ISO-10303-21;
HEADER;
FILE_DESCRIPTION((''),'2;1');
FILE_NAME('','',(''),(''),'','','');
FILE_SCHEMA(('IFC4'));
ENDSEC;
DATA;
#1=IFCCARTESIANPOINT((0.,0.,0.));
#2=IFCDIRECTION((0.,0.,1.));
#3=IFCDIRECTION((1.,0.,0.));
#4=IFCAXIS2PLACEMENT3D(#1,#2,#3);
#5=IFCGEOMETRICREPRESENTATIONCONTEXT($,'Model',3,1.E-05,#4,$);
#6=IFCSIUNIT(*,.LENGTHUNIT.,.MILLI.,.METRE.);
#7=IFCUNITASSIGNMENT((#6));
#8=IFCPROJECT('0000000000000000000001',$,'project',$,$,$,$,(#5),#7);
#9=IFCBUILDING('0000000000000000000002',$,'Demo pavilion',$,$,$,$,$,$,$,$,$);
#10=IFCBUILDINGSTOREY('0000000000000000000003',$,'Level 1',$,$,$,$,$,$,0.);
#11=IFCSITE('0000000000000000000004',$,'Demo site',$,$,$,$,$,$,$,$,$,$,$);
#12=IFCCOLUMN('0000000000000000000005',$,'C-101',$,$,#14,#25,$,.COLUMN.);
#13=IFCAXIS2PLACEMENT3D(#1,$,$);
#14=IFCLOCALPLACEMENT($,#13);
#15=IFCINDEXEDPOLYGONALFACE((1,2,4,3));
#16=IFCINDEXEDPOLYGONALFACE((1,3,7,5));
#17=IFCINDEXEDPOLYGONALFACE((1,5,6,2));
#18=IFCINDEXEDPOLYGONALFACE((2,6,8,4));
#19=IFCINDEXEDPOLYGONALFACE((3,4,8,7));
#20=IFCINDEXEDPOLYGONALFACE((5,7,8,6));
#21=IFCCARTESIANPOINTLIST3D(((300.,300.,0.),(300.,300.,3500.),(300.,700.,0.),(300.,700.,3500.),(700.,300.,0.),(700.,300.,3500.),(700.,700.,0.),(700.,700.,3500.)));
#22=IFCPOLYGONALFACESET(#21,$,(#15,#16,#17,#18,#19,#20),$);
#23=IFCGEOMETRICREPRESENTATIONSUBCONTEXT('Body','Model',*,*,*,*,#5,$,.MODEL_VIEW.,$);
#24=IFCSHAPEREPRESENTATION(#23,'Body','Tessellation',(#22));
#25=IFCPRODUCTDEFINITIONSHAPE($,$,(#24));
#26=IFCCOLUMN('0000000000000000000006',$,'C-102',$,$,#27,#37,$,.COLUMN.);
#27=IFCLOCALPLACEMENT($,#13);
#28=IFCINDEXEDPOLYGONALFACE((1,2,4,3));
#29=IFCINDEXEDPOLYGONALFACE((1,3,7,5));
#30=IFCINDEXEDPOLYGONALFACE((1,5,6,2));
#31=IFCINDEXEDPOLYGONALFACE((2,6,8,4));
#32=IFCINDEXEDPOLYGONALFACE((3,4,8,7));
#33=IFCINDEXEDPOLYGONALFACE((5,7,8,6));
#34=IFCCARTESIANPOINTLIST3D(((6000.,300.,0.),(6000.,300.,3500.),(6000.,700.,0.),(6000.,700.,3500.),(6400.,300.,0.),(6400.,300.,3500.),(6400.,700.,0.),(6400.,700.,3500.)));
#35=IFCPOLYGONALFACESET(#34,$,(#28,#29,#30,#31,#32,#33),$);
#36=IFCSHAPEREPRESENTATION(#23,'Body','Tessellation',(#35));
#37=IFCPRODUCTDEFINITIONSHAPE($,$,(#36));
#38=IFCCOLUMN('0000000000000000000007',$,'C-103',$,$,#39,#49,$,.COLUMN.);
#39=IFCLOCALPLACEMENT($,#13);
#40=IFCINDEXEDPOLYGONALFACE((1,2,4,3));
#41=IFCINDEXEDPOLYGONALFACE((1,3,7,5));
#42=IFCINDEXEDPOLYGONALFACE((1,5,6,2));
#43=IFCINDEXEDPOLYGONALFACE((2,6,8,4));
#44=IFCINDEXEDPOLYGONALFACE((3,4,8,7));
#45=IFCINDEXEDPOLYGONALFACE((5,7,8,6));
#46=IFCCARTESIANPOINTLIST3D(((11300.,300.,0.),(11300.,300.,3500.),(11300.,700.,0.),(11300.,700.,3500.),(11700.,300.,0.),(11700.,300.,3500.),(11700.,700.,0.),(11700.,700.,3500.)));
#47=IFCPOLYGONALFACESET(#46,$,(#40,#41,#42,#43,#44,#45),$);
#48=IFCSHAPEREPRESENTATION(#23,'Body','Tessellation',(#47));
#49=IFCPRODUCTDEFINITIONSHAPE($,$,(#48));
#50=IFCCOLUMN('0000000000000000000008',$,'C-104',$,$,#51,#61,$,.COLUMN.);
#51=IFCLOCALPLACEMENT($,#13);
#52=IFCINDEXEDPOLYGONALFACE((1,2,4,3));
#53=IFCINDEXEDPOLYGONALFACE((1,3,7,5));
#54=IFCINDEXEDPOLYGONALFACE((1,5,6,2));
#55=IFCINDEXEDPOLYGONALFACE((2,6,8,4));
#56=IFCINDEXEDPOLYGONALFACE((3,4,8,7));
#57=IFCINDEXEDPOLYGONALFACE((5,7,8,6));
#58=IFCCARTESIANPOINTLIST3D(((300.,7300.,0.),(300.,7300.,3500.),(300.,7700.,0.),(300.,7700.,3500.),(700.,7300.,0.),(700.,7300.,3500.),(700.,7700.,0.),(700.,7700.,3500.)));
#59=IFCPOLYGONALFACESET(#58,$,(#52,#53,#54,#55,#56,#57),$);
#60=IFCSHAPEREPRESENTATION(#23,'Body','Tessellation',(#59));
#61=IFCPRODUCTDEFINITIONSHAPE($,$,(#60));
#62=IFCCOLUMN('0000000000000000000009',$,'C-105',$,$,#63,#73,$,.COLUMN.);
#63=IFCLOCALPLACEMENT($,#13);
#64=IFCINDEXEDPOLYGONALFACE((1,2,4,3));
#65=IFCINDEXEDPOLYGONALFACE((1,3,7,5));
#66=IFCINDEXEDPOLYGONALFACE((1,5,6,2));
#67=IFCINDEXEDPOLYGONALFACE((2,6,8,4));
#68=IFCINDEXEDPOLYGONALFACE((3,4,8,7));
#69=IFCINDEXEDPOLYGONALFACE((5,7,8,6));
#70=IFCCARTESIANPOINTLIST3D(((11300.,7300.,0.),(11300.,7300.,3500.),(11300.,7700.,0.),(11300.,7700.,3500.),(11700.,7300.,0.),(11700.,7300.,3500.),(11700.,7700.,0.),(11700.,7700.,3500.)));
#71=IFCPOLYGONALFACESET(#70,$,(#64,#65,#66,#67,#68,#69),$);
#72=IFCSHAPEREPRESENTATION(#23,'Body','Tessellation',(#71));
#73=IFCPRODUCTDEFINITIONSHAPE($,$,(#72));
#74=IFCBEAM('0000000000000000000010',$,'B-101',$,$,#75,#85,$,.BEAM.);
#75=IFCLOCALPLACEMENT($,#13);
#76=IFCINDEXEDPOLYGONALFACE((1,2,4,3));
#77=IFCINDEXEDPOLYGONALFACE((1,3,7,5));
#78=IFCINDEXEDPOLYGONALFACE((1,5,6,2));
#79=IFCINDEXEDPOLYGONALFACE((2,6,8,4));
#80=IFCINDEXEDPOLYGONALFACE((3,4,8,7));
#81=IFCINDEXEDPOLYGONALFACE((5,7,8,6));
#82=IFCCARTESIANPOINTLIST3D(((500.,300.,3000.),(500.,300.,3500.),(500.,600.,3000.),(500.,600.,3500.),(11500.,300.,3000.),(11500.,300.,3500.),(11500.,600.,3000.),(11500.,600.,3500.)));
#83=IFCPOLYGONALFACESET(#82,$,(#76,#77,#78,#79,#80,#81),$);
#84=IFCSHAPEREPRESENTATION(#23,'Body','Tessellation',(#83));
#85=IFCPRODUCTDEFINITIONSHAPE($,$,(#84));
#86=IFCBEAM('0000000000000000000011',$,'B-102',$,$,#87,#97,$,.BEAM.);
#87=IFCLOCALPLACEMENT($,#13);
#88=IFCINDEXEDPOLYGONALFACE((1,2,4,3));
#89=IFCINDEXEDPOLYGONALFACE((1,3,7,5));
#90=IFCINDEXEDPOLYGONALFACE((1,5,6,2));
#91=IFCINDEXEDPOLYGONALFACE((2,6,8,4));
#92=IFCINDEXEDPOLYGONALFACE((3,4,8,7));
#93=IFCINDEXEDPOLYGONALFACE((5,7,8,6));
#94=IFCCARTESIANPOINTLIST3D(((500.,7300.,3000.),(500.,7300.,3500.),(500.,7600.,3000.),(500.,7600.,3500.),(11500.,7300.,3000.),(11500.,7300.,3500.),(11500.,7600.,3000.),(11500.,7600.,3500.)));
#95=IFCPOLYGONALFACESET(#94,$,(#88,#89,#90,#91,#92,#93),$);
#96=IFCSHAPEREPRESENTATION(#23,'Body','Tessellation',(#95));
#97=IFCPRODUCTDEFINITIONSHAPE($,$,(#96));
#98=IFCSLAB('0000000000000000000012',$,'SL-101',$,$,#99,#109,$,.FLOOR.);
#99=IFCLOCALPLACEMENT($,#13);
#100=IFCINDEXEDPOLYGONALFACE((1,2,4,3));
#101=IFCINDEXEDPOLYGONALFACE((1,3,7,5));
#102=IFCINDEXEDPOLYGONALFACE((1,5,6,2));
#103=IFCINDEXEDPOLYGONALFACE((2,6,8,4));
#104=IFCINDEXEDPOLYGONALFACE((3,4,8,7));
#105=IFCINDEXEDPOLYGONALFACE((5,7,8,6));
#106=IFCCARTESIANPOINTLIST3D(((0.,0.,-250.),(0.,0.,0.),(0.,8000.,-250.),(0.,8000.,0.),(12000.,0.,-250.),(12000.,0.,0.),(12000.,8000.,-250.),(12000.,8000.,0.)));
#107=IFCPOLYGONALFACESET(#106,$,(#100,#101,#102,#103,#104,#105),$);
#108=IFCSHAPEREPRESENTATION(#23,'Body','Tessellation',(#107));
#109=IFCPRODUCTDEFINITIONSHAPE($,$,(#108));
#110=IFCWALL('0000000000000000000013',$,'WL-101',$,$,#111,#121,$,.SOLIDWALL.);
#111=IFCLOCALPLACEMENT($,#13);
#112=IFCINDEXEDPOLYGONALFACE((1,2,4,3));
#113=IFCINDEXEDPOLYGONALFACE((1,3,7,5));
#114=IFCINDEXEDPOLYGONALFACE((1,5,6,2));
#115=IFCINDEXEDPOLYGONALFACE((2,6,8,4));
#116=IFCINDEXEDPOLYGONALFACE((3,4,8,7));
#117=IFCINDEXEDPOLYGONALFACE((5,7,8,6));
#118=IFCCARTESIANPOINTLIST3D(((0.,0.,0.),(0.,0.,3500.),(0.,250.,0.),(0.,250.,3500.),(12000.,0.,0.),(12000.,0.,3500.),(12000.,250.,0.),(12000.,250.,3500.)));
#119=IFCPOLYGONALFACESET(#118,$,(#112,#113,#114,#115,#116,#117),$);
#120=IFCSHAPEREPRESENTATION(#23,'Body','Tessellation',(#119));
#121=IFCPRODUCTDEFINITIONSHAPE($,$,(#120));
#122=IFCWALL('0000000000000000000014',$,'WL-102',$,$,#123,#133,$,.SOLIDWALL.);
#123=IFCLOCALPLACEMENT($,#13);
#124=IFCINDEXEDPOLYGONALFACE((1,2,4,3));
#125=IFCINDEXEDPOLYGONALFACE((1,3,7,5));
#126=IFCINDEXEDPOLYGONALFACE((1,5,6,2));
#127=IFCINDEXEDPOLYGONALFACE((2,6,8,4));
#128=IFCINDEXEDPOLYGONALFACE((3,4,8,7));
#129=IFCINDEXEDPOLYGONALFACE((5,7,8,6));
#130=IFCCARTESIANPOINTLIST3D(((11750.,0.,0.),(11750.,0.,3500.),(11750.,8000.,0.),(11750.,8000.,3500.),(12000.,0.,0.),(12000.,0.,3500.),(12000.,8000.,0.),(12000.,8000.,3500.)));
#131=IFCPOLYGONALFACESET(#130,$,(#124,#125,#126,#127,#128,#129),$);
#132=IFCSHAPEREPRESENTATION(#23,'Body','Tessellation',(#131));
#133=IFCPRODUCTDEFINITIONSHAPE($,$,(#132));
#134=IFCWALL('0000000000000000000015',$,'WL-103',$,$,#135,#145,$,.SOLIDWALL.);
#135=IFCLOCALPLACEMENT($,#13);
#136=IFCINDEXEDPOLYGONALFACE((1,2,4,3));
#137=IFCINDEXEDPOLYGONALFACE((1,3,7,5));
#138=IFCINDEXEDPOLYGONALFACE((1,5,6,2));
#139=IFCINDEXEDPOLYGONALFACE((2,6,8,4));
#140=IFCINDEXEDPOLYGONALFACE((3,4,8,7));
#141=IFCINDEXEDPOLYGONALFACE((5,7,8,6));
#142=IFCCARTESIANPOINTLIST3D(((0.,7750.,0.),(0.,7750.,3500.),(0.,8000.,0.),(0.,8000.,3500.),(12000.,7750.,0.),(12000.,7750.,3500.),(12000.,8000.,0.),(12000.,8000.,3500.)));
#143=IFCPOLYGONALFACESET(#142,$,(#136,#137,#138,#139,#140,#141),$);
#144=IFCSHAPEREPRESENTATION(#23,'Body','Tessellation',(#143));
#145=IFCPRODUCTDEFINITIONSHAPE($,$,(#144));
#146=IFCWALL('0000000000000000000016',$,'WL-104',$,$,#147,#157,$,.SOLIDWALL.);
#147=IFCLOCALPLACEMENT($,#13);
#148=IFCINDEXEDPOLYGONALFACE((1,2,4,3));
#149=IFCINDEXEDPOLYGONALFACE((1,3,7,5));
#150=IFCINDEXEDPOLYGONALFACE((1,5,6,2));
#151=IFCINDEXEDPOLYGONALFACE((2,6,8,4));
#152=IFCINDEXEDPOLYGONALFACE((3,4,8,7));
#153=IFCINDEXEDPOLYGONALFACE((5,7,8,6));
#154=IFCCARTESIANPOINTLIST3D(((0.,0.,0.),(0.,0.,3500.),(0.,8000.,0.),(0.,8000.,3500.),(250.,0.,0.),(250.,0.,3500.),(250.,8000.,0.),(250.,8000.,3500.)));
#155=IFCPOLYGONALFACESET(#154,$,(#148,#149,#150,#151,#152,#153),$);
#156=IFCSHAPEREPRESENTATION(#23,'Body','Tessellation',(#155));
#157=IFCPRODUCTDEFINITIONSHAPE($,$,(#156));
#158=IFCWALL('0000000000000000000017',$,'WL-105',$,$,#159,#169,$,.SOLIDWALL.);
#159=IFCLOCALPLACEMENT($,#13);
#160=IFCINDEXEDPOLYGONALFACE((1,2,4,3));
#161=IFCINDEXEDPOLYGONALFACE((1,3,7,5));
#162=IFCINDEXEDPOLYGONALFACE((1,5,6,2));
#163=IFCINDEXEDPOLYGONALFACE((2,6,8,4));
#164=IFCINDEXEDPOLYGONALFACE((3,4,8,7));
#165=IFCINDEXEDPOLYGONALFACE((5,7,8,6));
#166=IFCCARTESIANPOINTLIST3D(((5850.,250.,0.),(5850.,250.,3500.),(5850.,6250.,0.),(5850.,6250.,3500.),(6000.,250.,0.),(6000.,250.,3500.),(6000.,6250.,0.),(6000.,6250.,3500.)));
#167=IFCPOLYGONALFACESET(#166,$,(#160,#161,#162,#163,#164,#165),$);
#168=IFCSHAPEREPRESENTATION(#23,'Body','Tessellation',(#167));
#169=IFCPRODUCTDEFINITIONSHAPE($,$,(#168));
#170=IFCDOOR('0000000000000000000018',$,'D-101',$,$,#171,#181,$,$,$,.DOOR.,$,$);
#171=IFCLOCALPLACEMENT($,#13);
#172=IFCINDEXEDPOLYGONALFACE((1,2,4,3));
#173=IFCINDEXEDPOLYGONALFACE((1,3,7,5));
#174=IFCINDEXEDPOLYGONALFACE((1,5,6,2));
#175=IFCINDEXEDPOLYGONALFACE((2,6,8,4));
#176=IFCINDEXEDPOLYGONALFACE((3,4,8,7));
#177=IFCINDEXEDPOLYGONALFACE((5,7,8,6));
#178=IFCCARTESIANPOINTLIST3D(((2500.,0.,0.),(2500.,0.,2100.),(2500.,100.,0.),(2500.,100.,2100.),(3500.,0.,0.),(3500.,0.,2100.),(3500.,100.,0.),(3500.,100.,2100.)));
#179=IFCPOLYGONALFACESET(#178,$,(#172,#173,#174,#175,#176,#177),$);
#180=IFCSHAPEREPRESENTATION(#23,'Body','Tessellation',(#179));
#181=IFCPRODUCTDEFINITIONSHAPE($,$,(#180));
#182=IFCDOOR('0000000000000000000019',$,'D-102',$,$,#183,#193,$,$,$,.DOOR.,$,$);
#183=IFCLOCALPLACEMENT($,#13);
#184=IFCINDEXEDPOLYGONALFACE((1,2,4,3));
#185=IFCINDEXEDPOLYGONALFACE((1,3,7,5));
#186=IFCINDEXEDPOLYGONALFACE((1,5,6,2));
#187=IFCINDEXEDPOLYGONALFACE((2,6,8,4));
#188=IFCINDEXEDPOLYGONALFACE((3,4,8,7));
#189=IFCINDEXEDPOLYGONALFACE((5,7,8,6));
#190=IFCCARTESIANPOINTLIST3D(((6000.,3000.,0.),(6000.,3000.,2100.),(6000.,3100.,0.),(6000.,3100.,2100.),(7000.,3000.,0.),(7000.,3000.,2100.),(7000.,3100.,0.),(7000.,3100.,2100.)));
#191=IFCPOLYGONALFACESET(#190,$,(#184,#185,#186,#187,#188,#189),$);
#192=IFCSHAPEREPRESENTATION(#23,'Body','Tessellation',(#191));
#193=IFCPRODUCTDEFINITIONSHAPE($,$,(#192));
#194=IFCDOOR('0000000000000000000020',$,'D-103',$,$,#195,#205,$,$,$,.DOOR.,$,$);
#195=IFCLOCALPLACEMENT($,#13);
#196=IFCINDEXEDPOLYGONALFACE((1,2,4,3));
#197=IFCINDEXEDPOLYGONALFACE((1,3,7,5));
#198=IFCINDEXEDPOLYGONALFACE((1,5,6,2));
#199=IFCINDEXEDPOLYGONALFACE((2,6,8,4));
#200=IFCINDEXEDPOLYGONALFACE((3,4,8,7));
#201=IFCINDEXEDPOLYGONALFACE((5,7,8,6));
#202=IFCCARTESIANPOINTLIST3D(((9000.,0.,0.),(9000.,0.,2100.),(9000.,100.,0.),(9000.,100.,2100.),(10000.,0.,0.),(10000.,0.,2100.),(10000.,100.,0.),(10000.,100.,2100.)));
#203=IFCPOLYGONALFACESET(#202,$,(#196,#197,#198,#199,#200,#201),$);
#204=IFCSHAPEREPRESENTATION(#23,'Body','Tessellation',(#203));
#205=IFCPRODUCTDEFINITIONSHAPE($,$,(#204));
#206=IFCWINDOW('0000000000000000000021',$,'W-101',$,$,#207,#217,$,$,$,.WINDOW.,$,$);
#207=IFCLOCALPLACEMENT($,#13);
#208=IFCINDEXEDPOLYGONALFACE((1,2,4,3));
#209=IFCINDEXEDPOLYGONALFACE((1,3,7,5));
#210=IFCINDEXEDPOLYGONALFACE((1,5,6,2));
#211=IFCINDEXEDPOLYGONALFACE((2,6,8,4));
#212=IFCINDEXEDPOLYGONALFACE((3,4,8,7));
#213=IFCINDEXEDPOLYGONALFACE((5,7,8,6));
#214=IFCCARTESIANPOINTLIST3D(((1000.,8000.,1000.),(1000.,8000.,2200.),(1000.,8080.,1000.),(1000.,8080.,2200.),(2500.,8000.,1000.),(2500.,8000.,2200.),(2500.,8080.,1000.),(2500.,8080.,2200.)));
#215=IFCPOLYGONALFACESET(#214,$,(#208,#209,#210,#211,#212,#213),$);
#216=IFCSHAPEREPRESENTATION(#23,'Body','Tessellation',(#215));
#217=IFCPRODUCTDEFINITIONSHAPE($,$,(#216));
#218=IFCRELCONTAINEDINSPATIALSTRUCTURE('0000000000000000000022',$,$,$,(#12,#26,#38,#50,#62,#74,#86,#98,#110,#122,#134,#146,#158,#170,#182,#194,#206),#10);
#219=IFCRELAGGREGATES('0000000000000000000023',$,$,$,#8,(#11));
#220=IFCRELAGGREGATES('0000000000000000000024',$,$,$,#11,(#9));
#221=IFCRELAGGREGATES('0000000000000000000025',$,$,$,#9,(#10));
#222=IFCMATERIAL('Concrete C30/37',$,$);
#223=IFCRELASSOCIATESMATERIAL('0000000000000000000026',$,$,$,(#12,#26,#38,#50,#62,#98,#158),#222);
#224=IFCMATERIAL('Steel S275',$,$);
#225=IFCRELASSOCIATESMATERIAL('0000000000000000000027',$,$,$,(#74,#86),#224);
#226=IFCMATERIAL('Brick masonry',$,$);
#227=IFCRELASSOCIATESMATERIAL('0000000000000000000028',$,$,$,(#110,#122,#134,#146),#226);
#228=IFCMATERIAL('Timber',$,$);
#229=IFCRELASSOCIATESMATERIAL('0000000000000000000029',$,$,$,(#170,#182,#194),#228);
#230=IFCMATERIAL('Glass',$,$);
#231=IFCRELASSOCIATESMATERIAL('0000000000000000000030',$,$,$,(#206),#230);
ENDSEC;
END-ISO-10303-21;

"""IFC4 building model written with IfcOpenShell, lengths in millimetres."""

from ifc_helpers import new_model, si_unit, frame, origin_with_axes, place, context, subcontext, project, spatial, indexed_curve, outline, extrude, material, element, save


model = new_model("IFC4")

# Units and contexts
model_context = context("Model", 3, precision=1e-05, world=origin_with_axes())
body_context = subcontext(model_context, "Body", "Model", "MODEL_VIEW")
ifc_project = project(units=[si_unit("LENGTHUNIT", "METRE", prefix="MILLI")], contexts=[model_context])

# Site, building, storey
site = spatial("IfcSite", under=ifc_project, Name="Demo site")
building = spatial("IfcBuilding", under=site, Name="Demo pavilion")
storey = spatial("IfcBuildingStorey", under=building, Name="Level 1", Elevation=0.0)

# Columns
ifc_material_1 = material(Name="Concrete C30/37")
for number, where, z_axis, x_axis, name in (
    (1, (300.0, 300.0, 0.0), (0.0, 0.0, 1.0), (1.0, 0.0, 0.0), "C-101"),
    (2, (6000.0, 300.0, 0.0), (0.0, 0.0, 1.0), (1.0, 0.0, 0.0), "C-102"),
    (3, (11300.0, 300.0, 0.0), (0.0, 0.0, 1.0), (1.0, 0.0, 0.0), "C-103"),
    (4, (300.0, 7300.0, 0.0), (0.0, 0.0, 1.0), (1.0, 0.0, 0.0), "C-104"),
    (5, (11300.0, 7300.0, 0.0), (0.0, 0.0, 1.0), (1.0, 0.0, 0.0), "C-105"),
):
    element("IfcColumn", number, at=place(None, frame(where, z_axis=z_axis, x_axis=x_axis)), inside=storey, material=ifc_material_1, Name=name, PredefinedType="COLUMN", context=body_context, shape_type="SweptSolid", body=[
        extrude(outline(indexed_curve([(0.0, 0.0), (0.0, 400.0), (400.0, 400.0), (400.0, 0.0), (0.0, 0.0)], self_intersect=False)), origin_with_axes(), (0.0, 0.0, 1.0), 3500.0),
    ])

# Beams
ifc_material_2 = material(Name="Steel S275")
for number, where, z_axis, x_axis, name in (
    (6, (500.0, 300.0, 3000.0), (0.0, 0.0, 1.0), (1.0, 0.0, 0.0), "B-101"),
    (7, (500.0, 7300.0, 3000.0), (0.0, 0.0, 1.0), (1.0, 0.0, 0.0), "B-102"),
):
    element("IfcBeam", number, at=place(None, frame(where, z_axis=z_axis, x_axis=x_axis)), inside=storey, material=ifc_material_2, Name=name, PredefinedType="BEAM", context=body_context, shape_type="SweptSolid", body=[
        extrude(outline(indexed_curve([(0.0, 0.0), (0.0, 300.0), (11000.0, 300.0), (11000.0, 0.0), (0.0, 0.0)], self_intersect=False)), origin_with_axes(), (0.0, 0.0, 1.0), 500.0),
    ])

# Slab
slab_placement = place(None, frame((0.0, 0.0, -250.0), z_axis=(0.0, 0.0, 1.0), x_axis=(1.0, 0.0, 0.0)))
element("IfcSlab", 8, at=slab_placement, inside=storey, material=ifc_material_1, Name="SL-101", PredefinedType="FLOOR", context=body_context, shape_type="SweptSolid", body=[
    extrude(outline(indexed_curve([(0.0, 0.0), (0.0, 8000.0), (12000.0, 8000.0), (12000.0, 0.0), (0.0, 0.0)], self_intersect=False)), origin_with_axes(), (0.0, 0.0, 1.0), 250.0),
])

# Walls
ifc_material_3 = material(Name="Brick masonry")
wall_1_placement = place(None, origin_with_axes())
element("IfcWall", 9, at=wall_1_placement, inside=storey, material=ifc_material_3, Name="WL-101", PredefinedType="SOLIDWALL", context=body_context, shape_type="SweptSolid", body=[
    extrude(outline(indexed_curve([(0.0, 0.0), (0.0, 250.0), (12000.0, 250.0), (12000.0, 0.0), (0.0, 0.0)], self_intersect=False)), origin_with_axes(), (0.0, 0.0, 1.0), 3500.0),
])
wall_2_placement = place(None, frame((12000.0, 0.0, 0.0), z_axis=(0.0, 0.0, 1.0), x_axis=(0.0, 1.0, 0.0)))
element("IfcWall", 10, at=wall_2_placement, inside=storey, material=ifc_material_3, Name="WL-102", PredefinedType="SOLIDWALL", context=body_context, shape_type="SweptSolid", body=[
    extrude(outline(indexed_curve([(0.0, 0.0), (0.0, 250.0), (8000.0, 250.0), (8000.0, 0.0), (0.0, 0.0)], self_intersect=False)), origin_with_axes(), (0.0, 0.0, 1.0), 3500.0),
])
wall_3_placement = place(None, frame((12000.0, 8000.0, 0.0), z_axis=(0.0, 0.0, 1.0), x_axis=(-1.0, 0.0, 0.0)))
element("IfcWall", 11, at=wall_3_placement, inside=storey, material=ifc_material_3, Name="WL-103", PredefinedType="SOLIDWALL", context=body_context, shape_type="SweptSolid", body=[
    extrude(outline(indexed_curve([(0.0, 0.0), (0.0, 250.0), (12000.0, 250.0), (12000.0, 0.0), (0.0, 0.0)], self_intersect=False)), origin_with_axes(), (0.0, 0.0, 1.0), 3500.0),
])
wall_4_placement = place(None, frame((0.0, 8000.0, 0.0), z_axis=(0.0, 0.0, 1.0), x_axis=(0.0, -1.0, 0.0)))
element("IfcWall", 12, at=wall_4_placement, inside=storey, material=ifc_material_3, Name="WL-104", PredefinedType="SOLIDWALL", context=body_context, shape_type="SweptSolid", body=[
    extrude(outline(indexed_curve([(0.0, 0.0), (0.0, 250.0), (8000.0, 250.0), (8000.0, 0.0), (0.0, 0.0)], self_intersect=False)), origin_with_axes(), (0.0, 0.0, 1.0), 3500.0),
])
wall_5_placement = place(None, frame((6000.0, 250.0, 0.0), z_axis=(0.0, 0.0, 1.0), x_axis=(0.0, 1.0, 0.0)))
element("IfcWall", 13, at=wall_5_placement, inside=storey, material=ifc_material_1, Name="WL-105", PredefinedType="SOLIDWALL", context=body_context, shape_type="SweptSolid", body=[
    extrude(outline(indexed_curve([(0.0, 0.0), (0.0, 150.0), (6000.0, 150.0), (6000.0, 0.0), (0.0, 0.0)], self_intersect=False)), origin_with_axes(), (0.0, 0.0, 1.0), 3500.0),
])

# Doors
ifc_material_4 = material(Name="Timber")
for number, where, z_axis, x_axis, name in (
    (14, (2500.0, 0.0, 0.0), (0.0, 0.0, 1.0), (1.0, 0.0, 0.0), "D-101"),
    (15, (6000.0, 3000.0, 0.0), (0.0, 0.0, 1.0), (1.0, 0.0, 0.0), "D-102"),
    (16, (9000.0, 0.0, 0.0), (0.0, 0.0, 1.0), (1.0, 0.0, 0.0), "D-103"),
):
    element("IfcDoor", number, at=place(None, frame(where, z_axis=z_axis, x_axis=x_axis)), inside=storey, material=ifc_material_4, Name=name, PredefinedType="DOOR", context=body_context, shape_type="SweptSolid", body=[
        extrude(outline(indexed_curve([(0.0, 0.0), (0.0, 100.0), (1000.0, 100.0), (1000.0, 0.0), (0.0, 0.0)], self_intersect=False)), origin_with_axes(), (0.0, 0.0, 1.0), 2100.0),
    ])

# Window
ifc_material_5 = material(Name="Glass")
for number, where, z_axis, x_axis, name in (
    (17, (1000.0, 8000.0, 1000.0), (0.0, 0.0, 1.0), (1.0, 0.0, 0.0), "W-101"),
):
    element("IfcWindow", number, at=place(None, frame(where, z_axis=z_axis, x_axis=x_axis)), inside=storey, material=ifc_material_5, Name=name, PredefinedType="WINDOW", context=body_context, shape_type="SweptSolid", body=[
        extrude(outline(indexed_curve([(0.0, 0.0), (0.0, 80.0), (1500.0, 80.0), (1500.0, 0.0), (0.0, 0.0)], self_intersect=False)), origin_with_axes(), (0.0, 0.0, 1.0), 1200.0),
    ])

save(model, "model.ifc")
